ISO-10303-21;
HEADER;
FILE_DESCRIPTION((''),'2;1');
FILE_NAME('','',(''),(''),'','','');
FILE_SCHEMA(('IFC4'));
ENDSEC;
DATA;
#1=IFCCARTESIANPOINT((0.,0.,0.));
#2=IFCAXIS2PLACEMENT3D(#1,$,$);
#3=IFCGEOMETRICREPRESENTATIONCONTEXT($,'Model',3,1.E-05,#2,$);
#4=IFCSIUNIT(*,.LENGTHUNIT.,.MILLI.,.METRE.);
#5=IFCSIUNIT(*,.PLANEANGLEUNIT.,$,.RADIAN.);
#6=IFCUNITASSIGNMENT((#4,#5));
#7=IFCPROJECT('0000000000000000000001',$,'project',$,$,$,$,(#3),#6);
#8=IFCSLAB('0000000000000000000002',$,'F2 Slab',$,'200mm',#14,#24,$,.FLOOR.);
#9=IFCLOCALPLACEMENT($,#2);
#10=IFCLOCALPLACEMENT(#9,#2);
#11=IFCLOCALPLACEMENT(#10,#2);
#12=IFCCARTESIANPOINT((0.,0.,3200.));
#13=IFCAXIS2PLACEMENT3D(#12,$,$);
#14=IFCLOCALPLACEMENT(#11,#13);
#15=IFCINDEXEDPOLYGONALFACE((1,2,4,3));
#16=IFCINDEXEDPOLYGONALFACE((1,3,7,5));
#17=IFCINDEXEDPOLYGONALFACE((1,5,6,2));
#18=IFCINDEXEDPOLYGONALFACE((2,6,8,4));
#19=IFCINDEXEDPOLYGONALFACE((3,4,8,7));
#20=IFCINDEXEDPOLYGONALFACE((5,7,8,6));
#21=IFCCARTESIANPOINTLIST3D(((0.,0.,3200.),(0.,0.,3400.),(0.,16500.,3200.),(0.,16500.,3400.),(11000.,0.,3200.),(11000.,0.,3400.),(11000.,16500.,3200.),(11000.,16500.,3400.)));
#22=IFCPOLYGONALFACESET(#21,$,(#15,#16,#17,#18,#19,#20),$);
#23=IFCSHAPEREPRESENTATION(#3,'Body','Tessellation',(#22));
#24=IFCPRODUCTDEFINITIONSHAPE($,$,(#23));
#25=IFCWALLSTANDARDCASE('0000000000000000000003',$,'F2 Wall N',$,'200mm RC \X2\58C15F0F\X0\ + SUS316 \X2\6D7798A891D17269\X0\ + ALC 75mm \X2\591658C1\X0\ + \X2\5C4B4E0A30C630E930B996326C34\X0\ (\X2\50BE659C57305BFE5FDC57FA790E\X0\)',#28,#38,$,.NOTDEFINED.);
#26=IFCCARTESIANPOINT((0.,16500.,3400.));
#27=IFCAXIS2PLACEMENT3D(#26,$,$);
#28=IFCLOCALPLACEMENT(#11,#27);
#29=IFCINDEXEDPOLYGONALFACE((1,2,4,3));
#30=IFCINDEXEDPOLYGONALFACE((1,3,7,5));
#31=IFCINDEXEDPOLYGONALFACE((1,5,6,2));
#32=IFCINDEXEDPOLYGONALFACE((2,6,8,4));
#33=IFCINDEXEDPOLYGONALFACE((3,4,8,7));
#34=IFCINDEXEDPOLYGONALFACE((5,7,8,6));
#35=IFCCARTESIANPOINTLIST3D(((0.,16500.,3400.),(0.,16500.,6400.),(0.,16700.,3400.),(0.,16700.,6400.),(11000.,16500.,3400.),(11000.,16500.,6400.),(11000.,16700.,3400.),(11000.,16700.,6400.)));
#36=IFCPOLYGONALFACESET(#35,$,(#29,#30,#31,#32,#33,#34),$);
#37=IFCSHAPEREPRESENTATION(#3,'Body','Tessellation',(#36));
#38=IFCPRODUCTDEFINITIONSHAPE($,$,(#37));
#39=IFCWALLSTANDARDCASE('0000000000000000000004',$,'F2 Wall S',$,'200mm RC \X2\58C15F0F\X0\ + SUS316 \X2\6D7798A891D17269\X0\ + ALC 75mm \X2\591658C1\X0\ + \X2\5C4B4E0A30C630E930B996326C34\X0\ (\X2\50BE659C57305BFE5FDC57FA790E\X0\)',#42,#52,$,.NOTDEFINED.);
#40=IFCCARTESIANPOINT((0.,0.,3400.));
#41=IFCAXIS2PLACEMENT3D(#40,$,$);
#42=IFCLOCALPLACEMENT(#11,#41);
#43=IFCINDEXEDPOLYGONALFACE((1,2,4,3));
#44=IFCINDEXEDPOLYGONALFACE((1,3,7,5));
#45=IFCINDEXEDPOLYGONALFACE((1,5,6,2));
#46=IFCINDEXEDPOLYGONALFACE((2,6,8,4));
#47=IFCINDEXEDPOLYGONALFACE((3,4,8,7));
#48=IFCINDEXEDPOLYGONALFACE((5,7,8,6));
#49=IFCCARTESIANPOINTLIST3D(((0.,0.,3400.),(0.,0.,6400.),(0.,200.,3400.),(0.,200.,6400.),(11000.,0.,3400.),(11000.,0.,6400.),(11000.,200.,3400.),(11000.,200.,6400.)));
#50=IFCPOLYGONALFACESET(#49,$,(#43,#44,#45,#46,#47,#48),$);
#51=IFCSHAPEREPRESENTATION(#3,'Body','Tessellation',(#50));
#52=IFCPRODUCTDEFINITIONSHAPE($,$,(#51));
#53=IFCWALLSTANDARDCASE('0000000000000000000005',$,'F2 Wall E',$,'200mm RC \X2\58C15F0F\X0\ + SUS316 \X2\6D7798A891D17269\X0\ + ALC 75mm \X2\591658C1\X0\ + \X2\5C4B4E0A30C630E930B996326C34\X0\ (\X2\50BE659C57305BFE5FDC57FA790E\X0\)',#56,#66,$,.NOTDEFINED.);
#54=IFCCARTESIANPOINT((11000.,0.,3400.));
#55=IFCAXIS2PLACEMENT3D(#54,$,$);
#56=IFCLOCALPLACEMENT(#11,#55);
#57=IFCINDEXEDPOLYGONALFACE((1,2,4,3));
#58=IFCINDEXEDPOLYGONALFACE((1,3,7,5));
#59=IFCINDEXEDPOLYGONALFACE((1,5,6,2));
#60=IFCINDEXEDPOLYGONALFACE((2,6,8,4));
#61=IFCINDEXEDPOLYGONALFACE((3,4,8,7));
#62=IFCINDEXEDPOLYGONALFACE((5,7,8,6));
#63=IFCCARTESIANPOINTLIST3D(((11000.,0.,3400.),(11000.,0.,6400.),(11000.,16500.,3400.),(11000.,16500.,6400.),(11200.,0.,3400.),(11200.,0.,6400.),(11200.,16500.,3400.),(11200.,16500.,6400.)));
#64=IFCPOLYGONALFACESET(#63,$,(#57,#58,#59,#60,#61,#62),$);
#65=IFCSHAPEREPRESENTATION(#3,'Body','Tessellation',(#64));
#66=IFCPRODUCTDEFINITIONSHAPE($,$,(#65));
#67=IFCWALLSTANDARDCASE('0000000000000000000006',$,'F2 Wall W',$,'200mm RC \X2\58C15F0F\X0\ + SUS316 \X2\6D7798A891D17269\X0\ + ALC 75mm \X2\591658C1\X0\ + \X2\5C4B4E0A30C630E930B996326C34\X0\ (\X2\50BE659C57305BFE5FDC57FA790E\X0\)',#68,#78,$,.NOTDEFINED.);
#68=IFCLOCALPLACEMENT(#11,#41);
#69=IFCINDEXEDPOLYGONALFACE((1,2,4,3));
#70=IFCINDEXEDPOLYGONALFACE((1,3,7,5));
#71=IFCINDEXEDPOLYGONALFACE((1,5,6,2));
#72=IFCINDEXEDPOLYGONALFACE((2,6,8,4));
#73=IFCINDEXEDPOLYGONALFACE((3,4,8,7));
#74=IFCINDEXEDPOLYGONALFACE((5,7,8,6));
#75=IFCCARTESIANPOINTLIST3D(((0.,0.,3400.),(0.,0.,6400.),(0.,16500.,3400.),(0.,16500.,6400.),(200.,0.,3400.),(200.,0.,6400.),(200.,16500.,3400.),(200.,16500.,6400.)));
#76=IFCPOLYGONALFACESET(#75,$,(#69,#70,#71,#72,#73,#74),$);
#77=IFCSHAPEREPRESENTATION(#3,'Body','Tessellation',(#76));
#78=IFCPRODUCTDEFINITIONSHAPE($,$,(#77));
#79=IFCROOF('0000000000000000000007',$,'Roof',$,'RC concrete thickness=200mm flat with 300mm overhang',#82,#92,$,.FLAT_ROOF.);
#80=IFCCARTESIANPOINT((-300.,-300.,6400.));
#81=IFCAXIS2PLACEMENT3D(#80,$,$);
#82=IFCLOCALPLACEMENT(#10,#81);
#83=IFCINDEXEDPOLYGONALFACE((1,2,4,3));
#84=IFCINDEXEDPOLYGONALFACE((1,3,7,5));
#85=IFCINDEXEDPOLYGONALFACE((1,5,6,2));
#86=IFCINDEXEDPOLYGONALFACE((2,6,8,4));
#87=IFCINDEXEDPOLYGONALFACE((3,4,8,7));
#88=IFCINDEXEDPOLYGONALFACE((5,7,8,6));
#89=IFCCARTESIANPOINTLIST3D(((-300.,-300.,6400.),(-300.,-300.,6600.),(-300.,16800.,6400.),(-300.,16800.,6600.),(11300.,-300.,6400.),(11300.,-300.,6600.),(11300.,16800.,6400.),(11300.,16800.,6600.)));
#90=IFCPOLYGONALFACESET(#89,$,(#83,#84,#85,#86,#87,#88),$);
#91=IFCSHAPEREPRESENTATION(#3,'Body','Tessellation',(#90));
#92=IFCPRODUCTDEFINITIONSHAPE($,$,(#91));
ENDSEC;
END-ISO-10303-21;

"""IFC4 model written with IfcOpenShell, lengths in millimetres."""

from ifc_helpers import new_model, si_unit, frame, frame_2d, origin, place, context, project, rectangle, extrude, element, save


model = new_model("IFC4")

# Units and contexts
model_context = context("Model", 3, precision=1e-05, world=origin())
ifc_project = project(units=[si_unit("LENGTHUNIT", "METRE", prefix="MILLI"), si_unit("PLANEANGLEUNIT", "RADIAN")], contexts=[model_context])

# Slab
placement_1 = place(None, origin())
placement_2 = place(placement_1, origin())
placement_3 = place(placement_2, origin())
slab_placement = place(placement_3, frame((0.0, 0.0, 3200.0)))
element("IfcSlab", 1, at=slab_placement, Name="F2 Slab", ObjectType="200mm", PredefinedType="FLOOR", context=model_context, shape_type="SweptSolid", body=[
    extrude(rectangle(XDim=11000.0, YDim=16500.0, at=frame_2d((5500.0, 8250.0))), frame((0.0, 0.0, 3200.0)), (0.0, 0.0, 1.0), 200.0),
])

# Walls
wall_1_placement = place(placement_3, frame((0.0, 16500.0, 3400.0)))
element("IfcWallStandardCase", 2, at=wall_1_placement, Name="F2 Wall N", ObjectType="200mm RC 壁式 + SUS316 海風金物 + ALC 75mm 外壁 + 屋上テラス防水 (傾斜地対応基礎)", PredefinedType="NOTDEFINED", context=model_context, shape_type="SweptSolid", body=[
    extrude(rectangle(XDim=11000.0, YDim=200.0, at=frame_2d((5500.0, 100.0))), frame((0.0, 16500.0, 3400.0)), (0.0, 0.0, 1.0), 3000.0),
])
wall_2_placement = place(placement_3, frame((0.0, 0.0, 3400.0)))
element("IfcWallStandardCase", 3, at=wall_2_placement, Name="F2 Wall S", ObjectType="200mm RC 壁式 + SUS316 海風金物 + ALC 75mm 外壁 + 屋上テラス防水 (傾斜地対応基礎)", PredefinedType="NOTDEFINED", context=model_context, shape_type="SweptSolid", body=[
    extrude(rectangle(XDim=11000.0, YDim=200.0, at=frame_2d((5500.0, 100.0))), frame((0.0, 0.0, 3400.0)), (0.0, 0.0, 1.0), 3000.0),
])
wall_3_placement = place(placement_3, frame((11000.0, 0.0, 3400.0)))
element("IfcWallStandardCase", 4, at=wall_3_placement, Name="F2 Wall E", ObjectType="200mm RC 壁式 + SUS316 海風金物 + ALC 75mm 外壁 + 屋上テラス防水 (傾斜地対応基礎)", PredefinedType="NOTDEFINED", context=model_context, shape_type="SweptSolid", body=[
    extrude(rectangle(XDim=200.0, YDim=16500.0, at=frame_2d((100.0, 8250.0))), frame((11000.0, 0.0, 3400.0)), (0.0, 0.0, 1.0), 3000.0),
])
wall_4_placement = place(placement_3, frame((0.0, 0.0, 3400.0)))
element("IfcWallStandardCase", 5, at=wall_4_placement, Name="F2 Wall W", ObjectType="200mm RC 壁式 + SUS316 海風金物 + ALC 75mm 外壁 + 屋上テラス防水 (傾斜地対応基礎)", PredefinedType="NOTDEFINED", context=model_context, shape_type="SweptSolid", body=[
    extrude(rectangle(XDim=200.0, YDim=16500.0, at=frame_2d((100.0, 8250.0))), frame((0.0, 0.0, 3400.0)), (0.0, 0.0, 1.0), 3000.0),
])

# Roof
roof_placement = place(placement_2, frame((-300.0, -300.0, 6400.0)))
element("IfcRoof", 6, at=roof_placement, Name="Roof", ObjectType="RC concrete thickness=200mm flat with 300mm overhang", PredefinedType="FLAT_ROOF", context=model_context, shape_type="SweptSolid", body=[
    extrude(rectangle(XDim=11600.0, YDim=17100.0, at=frame_2d((5800.0, 8550.0))), frame((-300.0, -300.0, 6400.0)), (0.0, 0.0, 1.0), 200.0),
])

save(model, "model.ifc")
